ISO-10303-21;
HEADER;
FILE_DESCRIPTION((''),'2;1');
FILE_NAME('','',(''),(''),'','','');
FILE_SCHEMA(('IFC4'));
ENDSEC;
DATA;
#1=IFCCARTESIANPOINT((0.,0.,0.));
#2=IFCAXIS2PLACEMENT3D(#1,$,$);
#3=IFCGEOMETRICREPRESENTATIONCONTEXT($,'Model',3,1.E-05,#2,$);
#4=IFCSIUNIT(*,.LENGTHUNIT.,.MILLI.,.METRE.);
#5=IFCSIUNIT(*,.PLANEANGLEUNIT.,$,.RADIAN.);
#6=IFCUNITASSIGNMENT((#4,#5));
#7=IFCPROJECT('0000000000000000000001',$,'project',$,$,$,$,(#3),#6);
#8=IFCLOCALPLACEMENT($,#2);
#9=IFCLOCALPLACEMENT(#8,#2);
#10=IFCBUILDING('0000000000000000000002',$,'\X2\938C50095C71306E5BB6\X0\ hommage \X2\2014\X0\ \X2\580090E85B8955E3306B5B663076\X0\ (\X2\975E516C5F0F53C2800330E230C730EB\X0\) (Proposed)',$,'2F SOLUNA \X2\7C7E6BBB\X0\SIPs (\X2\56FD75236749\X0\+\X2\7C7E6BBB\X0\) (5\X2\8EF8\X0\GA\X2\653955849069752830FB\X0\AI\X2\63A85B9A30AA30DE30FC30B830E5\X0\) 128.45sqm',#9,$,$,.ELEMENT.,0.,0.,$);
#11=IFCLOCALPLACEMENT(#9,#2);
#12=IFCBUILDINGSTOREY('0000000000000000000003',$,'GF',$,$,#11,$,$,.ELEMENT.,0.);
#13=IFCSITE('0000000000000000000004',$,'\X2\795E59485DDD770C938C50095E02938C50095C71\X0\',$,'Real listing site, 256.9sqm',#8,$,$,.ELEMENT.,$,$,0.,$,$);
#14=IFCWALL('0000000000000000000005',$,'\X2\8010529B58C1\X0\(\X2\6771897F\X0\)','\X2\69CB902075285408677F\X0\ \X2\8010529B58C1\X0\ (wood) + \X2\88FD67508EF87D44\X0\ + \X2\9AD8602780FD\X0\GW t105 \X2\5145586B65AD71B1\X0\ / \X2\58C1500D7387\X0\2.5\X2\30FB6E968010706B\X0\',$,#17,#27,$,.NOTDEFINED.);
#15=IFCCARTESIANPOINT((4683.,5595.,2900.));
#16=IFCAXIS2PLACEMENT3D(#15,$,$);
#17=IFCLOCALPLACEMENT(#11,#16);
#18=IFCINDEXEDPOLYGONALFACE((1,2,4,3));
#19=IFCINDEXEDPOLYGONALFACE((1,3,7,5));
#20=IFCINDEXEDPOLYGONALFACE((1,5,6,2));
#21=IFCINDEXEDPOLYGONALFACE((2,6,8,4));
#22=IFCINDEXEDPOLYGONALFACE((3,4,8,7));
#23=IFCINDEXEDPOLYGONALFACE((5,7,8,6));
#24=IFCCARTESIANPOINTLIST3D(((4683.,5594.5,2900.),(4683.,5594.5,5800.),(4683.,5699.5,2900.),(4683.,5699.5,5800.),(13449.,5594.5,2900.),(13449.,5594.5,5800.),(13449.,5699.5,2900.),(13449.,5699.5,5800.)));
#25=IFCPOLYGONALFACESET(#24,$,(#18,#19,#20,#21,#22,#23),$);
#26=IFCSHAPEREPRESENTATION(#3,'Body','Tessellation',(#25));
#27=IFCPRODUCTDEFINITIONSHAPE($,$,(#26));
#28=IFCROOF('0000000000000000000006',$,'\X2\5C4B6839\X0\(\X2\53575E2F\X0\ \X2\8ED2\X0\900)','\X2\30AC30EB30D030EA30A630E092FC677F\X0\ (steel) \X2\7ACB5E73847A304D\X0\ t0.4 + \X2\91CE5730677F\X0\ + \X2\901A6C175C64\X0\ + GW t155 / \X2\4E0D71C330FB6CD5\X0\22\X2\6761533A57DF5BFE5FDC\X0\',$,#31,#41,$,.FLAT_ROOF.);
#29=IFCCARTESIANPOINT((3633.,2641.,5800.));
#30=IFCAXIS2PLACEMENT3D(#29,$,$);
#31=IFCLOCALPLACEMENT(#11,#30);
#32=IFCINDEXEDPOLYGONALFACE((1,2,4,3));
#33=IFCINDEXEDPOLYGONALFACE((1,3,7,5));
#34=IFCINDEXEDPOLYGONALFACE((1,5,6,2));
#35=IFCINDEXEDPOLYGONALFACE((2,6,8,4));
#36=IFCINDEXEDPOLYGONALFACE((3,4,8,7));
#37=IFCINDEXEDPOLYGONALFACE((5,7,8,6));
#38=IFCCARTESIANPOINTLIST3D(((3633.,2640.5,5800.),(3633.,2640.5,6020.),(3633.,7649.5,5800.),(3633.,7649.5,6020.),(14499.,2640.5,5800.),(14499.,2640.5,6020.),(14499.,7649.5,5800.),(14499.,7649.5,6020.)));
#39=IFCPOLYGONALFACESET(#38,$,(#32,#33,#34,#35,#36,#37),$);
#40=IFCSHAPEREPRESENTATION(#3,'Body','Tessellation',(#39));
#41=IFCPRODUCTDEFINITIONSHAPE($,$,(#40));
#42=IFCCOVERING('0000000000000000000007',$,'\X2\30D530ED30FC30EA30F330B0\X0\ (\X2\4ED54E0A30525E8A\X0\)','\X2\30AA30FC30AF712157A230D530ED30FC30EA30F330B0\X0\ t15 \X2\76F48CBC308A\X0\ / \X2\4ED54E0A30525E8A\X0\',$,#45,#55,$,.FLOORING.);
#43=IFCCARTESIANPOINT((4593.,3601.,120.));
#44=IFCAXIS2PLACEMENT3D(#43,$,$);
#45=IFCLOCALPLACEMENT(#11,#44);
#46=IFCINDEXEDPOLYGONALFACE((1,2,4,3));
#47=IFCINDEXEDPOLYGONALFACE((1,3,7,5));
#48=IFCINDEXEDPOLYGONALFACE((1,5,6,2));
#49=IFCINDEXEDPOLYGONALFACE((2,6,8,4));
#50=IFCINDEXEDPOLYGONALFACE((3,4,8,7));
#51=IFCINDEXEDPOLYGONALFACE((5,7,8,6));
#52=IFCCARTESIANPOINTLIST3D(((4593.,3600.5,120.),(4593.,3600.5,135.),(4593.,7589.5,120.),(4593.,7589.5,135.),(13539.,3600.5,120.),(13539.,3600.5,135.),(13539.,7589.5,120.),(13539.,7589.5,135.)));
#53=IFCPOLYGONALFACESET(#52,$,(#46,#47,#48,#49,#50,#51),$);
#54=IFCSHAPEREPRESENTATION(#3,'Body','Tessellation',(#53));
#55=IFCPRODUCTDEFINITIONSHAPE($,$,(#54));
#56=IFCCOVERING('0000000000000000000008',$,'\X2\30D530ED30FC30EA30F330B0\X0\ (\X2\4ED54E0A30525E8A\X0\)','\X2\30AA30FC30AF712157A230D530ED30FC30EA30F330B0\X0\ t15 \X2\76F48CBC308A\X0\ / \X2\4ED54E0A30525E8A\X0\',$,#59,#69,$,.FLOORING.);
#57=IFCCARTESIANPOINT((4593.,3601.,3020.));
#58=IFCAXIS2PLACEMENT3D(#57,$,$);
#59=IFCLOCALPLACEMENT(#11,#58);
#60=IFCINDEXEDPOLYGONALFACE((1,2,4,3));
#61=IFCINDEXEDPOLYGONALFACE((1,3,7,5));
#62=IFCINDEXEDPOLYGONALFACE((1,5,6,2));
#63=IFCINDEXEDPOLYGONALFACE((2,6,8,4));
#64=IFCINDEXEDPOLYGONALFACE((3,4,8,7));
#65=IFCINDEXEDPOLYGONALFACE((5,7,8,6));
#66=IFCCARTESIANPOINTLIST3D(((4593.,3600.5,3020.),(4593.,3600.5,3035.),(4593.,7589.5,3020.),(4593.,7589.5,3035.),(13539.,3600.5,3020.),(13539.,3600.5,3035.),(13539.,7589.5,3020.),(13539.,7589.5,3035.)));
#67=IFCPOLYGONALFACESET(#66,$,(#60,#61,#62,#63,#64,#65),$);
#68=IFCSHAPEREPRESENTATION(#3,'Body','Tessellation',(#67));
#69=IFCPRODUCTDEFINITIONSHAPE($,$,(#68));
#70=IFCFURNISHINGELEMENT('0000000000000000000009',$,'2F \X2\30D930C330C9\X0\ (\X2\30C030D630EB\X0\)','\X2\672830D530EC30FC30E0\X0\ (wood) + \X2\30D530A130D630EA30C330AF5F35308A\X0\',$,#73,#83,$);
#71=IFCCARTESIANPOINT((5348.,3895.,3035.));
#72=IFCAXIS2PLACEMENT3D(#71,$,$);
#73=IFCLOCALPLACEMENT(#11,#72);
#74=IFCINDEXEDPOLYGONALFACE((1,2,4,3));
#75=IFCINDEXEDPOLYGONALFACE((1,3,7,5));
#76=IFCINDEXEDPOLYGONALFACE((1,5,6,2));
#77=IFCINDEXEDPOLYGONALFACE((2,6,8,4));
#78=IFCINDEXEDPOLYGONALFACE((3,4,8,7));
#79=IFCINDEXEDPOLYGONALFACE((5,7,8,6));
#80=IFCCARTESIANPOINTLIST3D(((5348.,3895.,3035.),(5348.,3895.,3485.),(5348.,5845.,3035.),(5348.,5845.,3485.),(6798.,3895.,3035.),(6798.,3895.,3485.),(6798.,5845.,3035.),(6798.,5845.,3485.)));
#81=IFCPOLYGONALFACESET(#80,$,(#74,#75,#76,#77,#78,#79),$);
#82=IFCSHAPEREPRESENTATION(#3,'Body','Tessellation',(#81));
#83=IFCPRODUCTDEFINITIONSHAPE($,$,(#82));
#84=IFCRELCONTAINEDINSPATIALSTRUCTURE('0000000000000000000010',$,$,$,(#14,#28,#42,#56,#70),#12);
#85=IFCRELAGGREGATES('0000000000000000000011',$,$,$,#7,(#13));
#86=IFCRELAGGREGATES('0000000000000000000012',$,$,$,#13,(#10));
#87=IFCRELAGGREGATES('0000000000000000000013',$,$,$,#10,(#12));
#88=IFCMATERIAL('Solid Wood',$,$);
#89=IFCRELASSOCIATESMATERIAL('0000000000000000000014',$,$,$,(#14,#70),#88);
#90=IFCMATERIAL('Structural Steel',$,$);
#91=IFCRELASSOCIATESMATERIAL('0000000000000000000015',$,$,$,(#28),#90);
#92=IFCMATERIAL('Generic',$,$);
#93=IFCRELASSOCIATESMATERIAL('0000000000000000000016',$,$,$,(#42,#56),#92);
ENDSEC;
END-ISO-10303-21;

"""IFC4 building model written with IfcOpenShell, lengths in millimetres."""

from ifc_helpers import new_model, si_unit, frame, frame_2d, origin, place, context, project, spatial, rectangle, extrude, material, element, save


model = new_model("IFC4")

# Units and contexts
model_context = context("Model", 3, precision=1e-05, world=origin())
ifc_project = project(units=[si_unit("LENGTHUNIT", "METRE", prefix="MILLI"), si_unit("PLANEANGLEUNIT", "RADIAN")], contexts=[model_context])

# Site, building, storey
site_placement = place(None, origin())
site = spatial("IfcSite", under=ifc_project, at=site_placement, Name="神奈川県鎌倉市鎌倉山", ObjectType="Real listing site, 256.9sqm", CompositionType="ELEMENT", RefElevation=0.0)
building_placement = place(site_placement, origin())
building = spatial("IfcBuilding", under=site, at=building_placement, Name="鎌倉山の家 hommage — 堀部安嗣に学ぶ (非公式参考モデル) (Proposed)", ObjectType="2F SOLUNA 籾殻SIPs (国産杉+籾殻) (5軸GA改善適用・AI推定オマージュ) 128.45sqm", CompositionType="ELEMENT", ElevationOfRefHeight=0.0, ElevationOfTerrain=0.0)
storey_placement = place(building_placement, origin())
storey = spatial("IfcBuildingStorey", under=building, at=storey_placement, Name="GF", CompositionType="ELEMENT", Elevation=0.0)

# Shared definitions
ifc_material_1 = material(Name="Solid Wood")

# Wall
wall_1_placement = place(storey_placement, frame((4683.0, 5595.0, 2900.0)))
element("IfcWall", 1, at=wall_1_placement, inside=storey, material=ifc_material_1, Name="耐力壁(東西)", Description="構造用合板 耐力壁 (wood) + 製材軸組 + 高性能GW t105 充填断熱 / 壁倍率2.5・準耐火", PredefinedType="NOTDEFINED", context=model_context, shape_type="SweptSolid", body=[
    extrude(rectangle(XDim=8766.0, YDim=105.0, at=frame_2d((4383.0, 52.0))), frame((4683.0, 5595.0, 2900.0)), (0.0, 0.0, 1.0), 2900.0),
])

# Roof
ifc_material_2 = material(Name="Structural Steel")
for number, where, name in (
    (2, (3633.0, 2641.0, 5800.0), "屋根(南帯 軒900)"),
):
    element("IfcRoof", number, at=place(storey_placement, frame(where)), inside=storey, material=ifc_material_2, Name=name, Description="ガルバリウム鋼板 (steel) 立平葺き t0.4 + 野地板 + 通気層 + GW t155 / 不燃・法22条区域対応", PredefinedType="FLAT_ROOF", context=model_context, shape_type="SweptSolid", body=[
        extrude(rectangle(XDim=10866.0, YDim=5009.0, at=frame_2d((5433.0, 2504.0))), frame((3633.0, 2641.0, 5800.0)), (0.0, 0.0, 1.0), 220.0),
    ])

# Coverings
ifc_material_3 = material(Name="Generic")
covering_1_placement = place(storey_placement, frame((4593.0, 3601.0, 120.0)))
element("IfcCovering", 3, at=covering_1_placement, inside=storey, material=ifc_material_3, Name="フローリング (仕上げ床)", Description="オーク無垢フローリング t15 直貼り / 仕上げ床", PredefinedType="FLOORING", context=model_context, shape_type="SweptSolid", body=[
    extrude(rectangle(XDim=8946.0, YDim=3989.0, at=frame_2d((4473.0, 1994.0))), frame((4593.0, 3601.0, 120.0)), (0.0, 0.0, 1.0), 15.0),
])
covering_2_placement = place(storey_placement, frame((4593.0, 3601.0, 3020.0)))
element("IfcCovering", 4, at=covering_2_placement, inside=storey, material=ifc_material_3, Name="フローリング (仕上げ床)", Description="オーク無垢フローリング t15 直貼り / 仕上げ床", PredefinedType="FLOORING", context=model_context, shape_type="SweptSolid", body=[
    extrude(rectangle(XDim=8946.0, YDim=3989.0, at=frame_2d((4473.0, 1994.0))), frame((4593.0, 3601.0, 3020.0)), (0.0, 0.0, 1.0), 15.0),
])

# Furnishing element
furnishing_placement = place(storey_placement, frame((5348.0, 3895.0, 3035.0)))
element("IfcFurnishingElement", 5, at=furnishing_placement, inside=storey, material=ifc_material_1, Name="2F ベッド (ダブル)", Description="木フレーム (wood) + ファブリック張り", context=model_context, shape_type="SweptSolid", body=[
    extrude(rectangle(XDim=1450.0, YDim=1950.0, at=frame_2d((725.0, 975.0))), frame((5348.0, 3895.0, 3035.0)), (0.0, 0.0, 1.0), 450.0),
])

save(model, "model.ifc")
